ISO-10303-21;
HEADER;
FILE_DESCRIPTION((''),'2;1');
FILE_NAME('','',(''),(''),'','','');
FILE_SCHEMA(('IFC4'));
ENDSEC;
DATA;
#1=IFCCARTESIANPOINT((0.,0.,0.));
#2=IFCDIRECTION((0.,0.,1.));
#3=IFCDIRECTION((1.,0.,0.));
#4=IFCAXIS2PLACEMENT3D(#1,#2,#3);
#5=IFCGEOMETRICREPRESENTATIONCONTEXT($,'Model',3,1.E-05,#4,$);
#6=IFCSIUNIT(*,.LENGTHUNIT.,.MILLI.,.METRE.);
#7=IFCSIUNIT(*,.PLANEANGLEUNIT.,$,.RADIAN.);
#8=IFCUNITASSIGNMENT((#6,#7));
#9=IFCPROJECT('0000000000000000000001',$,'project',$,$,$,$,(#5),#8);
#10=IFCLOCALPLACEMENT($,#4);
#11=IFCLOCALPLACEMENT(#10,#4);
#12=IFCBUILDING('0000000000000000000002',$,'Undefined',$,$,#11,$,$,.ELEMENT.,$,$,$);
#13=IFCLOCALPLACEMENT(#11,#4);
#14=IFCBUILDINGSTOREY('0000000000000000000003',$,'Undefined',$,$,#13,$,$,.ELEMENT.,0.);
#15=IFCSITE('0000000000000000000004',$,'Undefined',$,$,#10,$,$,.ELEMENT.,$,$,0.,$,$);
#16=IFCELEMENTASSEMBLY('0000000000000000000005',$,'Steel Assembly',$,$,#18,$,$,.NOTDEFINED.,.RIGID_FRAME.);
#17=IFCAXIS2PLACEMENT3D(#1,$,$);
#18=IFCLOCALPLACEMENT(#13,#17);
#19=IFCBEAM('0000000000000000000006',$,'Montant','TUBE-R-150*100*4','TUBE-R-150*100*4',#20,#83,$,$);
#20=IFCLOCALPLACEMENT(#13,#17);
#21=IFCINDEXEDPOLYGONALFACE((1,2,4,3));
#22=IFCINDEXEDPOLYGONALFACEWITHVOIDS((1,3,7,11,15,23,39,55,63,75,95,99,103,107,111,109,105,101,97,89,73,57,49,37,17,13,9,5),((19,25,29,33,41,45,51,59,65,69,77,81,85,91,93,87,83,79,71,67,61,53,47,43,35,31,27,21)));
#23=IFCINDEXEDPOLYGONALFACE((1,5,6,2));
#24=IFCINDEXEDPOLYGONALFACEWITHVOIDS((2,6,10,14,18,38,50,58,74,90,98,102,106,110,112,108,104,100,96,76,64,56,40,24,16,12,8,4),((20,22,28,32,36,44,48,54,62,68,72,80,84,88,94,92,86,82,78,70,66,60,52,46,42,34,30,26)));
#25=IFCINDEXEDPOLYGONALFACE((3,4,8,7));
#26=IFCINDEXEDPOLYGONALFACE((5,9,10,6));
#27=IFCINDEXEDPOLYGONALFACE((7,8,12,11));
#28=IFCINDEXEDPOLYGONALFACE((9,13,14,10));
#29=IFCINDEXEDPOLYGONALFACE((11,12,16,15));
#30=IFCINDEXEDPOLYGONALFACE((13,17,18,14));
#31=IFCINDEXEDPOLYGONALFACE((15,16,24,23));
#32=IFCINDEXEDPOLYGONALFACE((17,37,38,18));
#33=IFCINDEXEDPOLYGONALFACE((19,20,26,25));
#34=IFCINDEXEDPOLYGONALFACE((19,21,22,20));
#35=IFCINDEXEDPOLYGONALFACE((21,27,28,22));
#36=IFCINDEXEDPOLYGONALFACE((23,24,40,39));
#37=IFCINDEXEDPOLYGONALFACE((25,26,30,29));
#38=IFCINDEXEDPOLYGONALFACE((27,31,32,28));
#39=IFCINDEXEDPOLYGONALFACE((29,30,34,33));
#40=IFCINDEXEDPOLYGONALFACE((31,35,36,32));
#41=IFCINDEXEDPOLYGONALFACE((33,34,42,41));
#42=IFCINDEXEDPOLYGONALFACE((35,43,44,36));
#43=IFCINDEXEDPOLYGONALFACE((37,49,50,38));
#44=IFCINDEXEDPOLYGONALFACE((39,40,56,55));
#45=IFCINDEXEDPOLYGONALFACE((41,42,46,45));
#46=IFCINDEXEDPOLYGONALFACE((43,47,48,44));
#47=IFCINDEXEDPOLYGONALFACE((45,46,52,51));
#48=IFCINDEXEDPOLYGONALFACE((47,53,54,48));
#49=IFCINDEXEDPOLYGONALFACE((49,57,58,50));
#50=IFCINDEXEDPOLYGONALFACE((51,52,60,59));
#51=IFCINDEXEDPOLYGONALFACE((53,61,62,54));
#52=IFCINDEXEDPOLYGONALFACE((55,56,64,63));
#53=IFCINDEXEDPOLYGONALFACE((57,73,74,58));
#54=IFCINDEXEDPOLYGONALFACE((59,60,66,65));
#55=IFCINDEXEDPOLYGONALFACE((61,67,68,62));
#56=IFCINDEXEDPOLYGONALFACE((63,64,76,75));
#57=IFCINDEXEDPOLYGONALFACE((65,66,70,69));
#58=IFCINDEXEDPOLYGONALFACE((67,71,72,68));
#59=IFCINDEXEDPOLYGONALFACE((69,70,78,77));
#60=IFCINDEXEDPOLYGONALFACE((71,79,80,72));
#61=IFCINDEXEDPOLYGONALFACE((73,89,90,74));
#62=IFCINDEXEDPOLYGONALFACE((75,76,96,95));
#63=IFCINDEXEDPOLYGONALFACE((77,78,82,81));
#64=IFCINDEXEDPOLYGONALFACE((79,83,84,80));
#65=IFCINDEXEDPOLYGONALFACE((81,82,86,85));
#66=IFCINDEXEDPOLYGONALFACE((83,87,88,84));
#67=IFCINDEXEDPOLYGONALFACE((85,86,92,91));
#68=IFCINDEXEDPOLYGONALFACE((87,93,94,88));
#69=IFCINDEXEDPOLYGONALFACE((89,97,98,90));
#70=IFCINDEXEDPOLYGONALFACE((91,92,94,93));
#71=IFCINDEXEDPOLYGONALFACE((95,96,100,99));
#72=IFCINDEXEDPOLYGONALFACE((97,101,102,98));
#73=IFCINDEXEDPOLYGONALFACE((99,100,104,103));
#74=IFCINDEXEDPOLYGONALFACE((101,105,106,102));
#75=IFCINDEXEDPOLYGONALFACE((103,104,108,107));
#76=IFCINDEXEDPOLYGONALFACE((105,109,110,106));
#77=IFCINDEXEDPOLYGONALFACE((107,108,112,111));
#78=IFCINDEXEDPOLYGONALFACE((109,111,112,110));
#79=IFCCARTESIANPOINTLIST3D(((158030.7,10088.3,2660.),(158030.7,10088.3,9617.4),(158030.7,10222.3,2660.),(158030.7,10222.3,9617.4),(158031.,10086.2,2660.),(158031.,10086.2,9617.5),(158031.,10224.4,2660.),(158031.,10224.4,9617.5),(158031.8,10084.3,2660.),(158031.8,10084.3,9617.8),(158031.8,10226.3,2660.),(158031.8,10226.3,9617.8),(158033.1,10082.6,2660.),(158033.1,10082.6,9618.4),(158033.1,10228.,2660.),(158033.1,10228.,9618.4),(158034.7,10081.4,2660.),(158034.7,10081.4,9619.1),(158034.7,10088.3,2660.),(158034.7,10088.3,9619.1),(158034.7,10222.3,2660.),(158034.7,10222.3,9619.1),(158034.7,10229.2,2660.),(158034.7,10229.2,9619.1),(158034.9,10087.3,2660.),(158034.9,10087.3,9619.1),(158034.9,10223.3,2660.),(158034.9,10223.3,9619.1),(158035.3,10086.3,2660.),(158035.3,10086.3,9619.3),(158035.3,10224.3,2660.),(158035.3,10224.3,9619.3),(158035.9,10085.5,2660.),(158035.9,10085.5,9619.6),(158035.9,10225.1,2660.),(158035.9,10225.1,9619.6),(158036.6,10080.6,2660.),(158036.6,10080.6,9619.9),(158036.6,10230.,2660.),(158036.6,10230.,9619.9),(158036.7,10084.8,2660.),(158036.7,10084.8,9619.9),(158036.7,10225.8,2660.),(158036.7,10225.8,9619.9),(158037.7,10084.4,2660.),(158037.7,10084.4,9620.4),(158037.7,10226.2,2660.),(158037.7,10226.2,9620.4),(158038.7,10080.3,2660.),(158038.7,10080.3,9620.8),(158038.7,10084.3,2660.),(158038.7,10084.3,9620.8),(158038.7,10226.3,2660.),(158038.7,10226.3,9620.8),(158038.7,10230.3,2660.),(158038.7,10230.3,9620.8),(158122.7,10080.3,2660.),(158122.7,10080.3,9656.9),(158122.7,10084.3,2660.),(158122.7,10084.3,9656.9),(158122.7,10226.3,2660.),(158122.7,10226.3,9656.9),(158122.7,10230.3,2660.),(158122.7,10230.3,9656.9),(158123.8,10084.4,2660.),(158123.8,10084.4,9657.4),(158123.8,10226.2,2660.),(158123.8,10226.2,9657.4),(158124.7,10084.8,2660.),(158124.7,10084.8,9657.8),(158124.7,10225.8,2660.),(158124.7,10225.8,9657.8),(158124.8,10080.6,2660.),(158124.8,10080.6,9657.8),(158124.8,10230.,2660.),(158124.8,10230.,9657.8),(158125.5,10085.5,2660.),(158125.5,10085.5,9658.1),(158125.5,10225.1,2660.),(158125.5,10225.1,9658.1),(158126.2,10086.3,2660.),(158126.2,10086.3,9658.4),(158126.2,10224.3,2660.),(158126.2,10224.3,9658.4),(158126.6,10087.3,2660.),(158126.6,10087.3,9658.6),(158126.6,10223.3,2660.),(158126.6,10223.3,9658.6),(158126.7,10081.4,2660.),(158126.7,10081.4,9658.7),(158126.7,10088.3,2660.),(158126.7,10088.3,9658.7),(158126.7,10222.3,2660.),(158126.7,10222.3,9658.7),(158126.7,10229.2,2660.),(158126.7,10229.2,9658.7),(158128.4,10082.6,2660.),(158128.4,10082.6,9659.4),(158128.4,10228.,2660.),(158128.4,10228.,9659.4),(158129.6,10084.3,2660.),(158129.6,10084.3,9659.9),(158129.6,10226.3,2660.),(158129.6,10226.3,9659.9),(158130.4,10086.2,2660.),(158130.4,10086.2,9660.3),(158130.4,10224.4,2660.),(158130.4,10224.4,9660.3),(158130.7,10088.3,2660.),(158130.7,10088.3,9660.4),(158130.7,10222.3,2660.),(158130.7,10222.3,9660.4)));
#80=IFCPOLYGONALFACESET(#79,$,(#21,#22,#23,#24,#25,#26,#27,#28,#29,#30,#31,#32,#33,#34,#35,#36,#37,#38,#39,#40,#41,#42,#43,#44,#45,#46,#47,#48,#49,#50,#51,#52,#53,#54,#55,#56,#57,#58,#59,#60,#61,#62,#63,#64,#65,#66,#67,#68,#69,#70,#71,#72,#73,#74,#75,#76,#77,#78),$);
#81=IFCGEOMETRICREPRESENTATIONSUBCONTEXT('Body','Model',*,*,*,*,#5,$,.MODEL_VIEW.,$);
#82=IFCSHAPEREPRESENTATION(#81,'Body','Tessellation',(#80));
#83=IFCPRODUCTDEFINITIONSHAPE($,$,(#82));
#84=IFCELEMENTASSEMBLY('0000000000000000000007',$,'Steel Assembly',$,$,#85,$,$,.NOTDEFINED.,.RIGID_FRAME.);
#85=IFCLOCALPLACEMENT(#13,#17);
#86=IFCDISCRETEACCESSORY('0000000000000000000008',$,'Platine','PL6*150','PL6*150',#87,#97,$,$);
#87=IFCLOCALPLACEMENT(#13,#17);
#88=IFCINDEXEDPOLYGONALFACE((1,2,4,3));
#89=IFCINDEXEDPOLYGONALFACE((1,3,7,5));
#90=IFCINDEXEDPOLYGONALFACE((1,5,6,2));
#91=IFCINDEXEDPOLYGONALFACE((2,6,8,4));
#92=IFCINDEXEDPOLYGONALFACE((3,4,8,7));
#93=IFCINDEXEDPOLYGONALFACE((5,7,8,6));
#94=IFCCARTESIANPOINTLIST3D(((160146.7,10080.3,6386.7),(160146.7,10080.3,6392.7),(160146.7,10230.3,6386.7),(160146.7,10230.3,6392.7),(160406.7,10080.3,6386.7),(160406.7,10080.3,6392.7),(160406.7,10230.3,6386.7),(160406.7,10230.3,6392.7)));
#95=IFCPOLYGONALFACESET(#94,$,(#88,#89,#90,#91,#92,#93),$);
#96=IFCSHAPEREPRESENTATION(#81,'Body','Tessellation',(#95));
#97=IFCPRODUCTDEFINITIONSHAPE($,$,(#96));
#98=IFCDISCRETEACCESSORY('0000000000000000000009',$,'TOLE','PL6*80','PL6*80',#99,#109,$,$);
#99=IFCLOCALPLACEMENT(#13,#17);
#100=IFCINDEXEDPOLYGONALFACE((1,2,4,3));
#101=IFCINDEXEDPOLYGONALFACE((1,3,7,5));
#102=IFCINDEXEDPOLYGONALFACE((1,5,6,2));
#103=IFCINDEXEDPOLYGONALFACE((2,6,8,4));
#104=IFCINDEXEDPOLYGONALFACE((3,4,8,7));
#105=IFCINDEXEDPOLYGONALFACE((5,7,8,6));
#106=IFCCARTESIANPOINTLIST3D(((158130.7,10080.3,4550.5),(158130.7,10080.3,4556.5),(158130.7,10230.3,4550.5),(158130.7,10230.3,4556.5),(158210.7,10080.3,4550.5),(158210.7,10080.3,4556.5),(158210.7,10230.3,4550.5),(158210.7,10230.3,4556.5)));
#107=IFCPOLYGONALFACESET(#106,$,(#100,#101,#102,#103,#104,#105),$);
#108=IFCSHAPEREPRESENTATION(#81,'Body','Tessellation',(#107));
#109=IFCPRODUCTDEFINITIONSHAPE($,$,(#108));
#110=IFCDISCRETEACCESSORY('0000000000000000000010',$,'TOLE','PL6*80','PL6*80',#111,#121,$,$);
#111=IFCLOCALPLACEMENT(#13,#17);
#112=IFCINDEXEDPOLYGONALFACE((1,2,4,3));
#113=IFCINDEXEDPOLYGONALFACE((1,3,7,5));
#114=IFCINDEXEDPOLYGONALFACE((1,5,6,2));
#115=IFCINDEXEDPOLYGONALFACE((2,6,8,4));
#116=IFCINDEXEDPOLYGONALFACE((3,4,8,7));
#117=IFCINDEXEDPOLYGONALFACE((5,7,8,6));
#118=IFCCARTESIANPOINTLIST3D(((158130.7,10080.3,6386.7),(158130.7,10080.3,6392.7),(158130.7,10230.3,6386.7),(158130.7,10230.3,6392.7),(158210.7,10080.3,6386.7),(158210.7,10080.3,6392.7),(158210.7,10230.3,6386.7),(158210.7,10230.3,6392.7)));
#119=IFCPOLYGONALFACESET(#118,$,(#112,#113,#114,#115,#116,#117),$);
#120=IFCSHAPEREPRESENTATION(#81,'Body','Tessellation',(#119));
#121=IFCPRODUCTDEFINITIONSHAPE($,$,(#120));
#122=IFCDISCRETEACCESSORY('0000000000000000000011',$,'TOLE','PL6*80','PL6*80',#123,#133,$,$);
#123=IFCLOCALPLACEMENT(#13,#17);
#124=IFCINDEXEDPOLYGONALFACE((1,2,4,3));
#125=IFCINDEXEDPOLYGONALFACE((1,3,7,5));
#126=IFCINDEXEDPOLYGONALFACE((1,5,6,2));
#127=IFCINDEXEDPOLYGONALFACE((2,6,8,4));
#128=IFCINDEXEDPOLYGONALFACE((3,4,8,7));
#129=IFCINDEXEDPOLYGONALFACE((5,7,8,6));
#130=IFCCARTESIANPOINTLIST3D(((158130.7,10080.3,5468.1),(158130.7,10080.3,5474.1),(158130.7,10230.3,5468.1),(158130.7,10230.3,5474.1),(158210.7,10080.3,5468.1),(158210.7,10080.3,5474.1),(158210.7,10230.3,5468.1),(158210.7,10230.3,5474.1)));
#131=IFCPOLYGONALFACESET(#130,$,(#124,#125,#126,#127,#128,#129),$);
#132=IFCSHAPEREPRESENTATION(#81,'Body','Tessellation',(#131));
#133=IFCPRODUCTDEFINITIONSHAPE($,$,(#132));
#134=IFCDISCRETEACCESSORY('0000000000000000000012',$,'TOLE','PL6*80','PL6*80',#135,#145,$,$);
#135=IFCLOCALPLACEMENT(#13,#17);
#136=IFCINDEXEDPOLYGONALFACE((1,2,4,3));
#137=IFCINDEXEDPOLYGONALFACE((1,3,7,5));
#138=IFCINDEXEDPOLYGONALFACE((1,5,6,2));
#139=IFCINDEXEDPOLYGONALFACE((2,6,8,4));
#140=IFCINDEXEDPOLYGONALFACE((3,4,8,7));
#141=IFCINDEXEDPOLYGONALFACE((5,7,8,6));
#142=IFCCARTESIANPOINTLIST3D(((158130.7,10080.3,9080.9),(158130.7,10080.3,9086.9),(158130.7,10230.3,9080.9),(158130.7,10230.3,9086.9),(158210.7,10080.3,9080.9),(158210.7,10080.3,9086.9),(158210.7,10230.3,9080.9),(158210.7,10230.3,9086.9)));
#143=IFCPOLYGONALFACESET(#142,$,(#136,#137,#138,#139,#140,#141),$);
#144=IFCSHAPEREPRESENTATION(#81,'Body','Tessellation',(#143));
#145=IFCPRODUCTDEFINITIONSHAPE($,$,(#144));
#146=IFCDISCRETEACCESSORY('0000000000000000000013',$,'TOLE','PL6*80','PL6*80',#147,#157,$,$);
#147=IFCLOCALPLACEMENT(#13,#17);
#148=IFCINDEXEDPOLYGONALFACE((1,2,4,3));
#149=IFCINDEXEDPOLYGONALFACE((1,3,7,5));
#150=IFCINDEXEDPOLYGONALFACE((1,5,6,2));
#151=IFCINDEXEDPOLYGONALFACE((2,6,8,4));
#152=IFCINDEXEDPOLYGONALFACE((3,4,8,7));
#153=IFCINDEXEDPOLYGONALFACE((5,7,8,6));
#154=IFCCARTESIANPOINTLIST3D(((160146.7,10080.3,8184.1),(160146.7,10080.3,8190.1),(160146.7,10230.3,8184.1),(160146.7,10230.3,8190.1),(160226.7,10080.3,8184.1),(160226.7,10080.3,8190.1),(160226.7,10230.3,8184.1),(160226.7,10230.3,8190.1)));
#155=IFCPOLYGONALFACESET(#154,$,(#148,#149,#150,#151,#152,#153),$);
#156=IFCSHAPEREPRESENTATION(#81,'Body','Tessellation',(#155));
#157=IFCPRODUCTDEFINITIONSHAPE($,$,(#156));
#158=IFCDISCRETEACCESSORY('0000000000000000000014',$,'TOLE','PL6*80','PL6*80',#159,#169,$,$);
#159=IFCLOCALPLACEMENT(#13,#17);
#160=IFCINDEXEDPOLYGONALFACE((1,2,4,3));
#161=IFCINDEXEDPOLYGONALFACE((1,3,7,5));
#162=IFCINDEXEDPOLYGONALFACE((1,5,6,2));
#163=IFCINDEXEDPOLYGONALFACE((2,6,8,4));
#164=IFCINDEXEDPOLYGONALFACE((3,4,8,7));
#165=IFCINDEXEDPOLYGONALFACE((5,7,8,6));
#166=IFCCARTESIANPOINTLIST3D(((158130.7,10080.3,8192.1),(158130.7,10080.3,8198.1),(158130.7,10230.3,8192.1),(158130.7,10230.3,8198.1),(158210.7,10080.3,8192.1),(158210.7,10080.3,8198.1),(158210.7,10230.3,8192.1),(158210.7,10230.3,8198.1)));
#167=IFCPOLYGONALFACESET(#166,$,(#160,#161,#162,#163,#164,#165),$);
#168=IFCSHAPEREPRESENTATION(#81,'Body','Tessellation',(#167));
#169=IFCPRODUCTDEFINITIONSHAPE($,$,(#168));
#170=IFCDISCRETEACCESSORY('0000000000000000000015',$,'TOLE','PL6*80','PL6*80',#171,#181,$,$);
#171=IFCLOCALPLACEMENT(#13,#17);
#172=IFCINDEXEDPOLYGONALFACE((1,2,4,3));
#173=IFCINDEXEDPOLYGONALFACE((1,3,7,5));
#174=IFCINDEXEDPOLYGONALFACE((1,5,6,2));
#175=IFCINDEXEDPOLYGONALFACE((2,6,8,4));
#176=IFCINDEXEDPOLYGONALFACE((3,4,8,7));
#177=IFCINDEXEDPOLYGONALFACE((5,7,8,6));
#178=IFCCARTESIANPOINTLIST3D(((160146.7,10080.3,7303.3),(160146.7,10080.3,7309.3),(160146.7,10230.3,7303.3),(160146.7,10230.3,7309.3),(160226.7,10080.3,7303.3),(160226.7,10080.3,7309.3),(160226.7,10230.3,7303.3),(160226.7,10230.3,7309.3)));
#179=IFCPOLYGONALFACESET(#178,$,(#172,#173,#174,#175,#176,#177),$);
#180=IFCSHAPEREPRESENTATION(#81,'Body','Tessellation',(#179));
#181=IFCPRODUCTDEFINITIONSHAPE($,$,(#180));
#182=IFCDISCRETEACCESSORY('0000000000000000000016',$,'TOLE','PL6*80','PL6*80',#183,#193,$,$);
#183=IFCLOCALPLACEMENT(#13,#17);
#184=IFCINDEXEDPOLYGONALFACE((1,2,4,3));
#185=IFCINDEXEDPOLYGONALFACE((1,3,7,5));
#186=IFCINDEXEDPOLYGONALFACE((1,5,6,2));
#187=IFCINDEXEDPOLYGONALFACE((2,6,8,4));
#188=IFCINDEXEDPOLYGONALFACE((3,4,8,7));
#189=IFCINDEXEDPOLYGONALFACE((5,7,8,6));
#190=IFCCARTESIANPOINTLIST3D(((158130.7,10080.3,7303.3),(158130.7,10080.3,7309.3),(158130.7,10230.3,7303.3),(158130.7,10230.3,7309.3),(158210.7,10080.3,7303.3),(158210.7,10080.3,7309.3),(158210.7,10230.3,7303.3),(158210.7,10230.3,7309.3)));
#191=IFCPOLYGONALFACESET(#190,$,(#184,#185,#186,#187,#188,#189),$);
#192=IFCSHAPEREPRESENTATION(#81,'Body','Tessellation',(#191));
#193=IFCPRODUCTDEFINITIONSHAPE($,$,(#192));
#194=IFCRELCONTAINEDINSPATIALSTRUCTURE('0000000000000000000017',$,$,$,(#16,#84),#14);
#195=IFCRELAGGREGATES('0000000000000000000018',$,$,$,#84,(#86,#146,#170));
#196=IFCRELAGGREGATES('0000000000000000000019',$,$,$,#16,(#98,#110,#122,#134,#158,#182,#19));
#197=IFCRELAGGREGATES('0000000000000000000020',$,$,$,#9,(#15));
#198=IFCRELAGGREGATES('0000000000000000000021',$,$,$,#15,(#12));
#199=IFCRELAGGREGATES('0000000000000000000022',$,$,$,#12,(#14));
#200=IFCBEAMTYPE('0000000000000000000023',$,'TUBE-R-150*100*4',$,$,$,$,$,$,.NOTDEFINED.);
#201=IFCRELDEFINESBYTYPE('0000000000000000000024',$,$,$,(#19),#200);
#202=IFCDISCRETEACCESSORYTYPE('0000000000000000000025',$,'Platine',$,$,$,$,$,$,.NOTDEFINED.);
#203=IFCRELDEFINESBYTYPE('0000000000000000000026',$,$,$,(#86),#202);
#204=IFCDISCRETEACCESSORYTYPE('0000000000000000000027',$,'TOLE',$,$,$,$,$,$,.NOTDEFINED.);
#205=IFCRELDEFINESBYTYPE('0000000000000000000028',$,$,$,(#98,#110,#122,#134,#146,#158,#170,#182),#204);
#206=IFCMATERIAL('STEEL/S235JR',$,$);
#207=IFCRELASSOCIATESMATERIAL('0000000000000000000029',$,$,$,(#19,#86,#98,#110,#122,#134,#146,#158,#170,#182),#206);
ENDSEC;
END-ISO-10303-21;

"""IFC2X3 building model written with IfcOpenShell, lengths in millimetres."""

from ifc_helpers import new_model, si_unit, frame, origin_with_axes, origin_2d_with_axis, place, context, subcontext, project, spatial, polyline, hollow_rectangle, outline, extrude, clip, halfspace, material, type_object, element, aggregate, save


model = new_model("IFC2X3")

# Units and contexts
model_context = context("Model", 3, precision=1e-05, world=origin_with_axes())
body_context = subcontext(model_context, "Body", "Model", "MODEL_VIEW")
ifc_project = project(units=[si_unit("LENGTHUNIT", "METRE", prefix="MILLI"), si_unit("PLANEANGLEUNIT", "RADIAN")], contexts=[model_context])

# Site, building, storey
site_placement = place(None, origin_with_axes())
site = spatial("IfcSite", under=ifc_project, at=site_placement, Name="Undefined", CompositionType="ELEMENT", RefElevation=0.0)
building_placement = place(site_placement, origin_with_axes())
building = spatial("IfcBuilding", under=site, at=building_placement, Name="Undefined", CompositionType="ELEMENT")
storey_placement = place(building_placement, origin_with_axes())
storey = spatial("IfcBuildingStorey", under=building, at=storey_placement, Name="Undefined", CompositionType="ELEMENT", Elevation=0.0)

# Element assembly, beam
assembly_1_placement = place(storey_placement, origin_with_axes())
assembly_1 = element("IfcElementAssembly", 1, at=assembly_1_placement, inside=storey, Name="Steel Assembly", AssemblyPlace="NOTDEFINED", PredefinedType="RIGID_FRAME")
ifc_material_1 = material(Name="STEEL/S235JR")
beam_type_1 = type_object("IfcBeamType", Name="TUBE-R-150*100*4", PredefinedType="NOTDEFINED")
beam_1_placement = place(assembly_1_placement, frame((158080.7, 10155.3, 9123.1), z_axis=(0.0, 1.0, 0.0), x_axis=(0.0, 0.0, -1.0)))
beam_1 = element("IfcBeam", 2, at=beam_1_placement, type_object=beam_type_1, material=ifc_material_1, Name="Montant", Description="TUBE-R-150*100*4", ObjectType="TUBE-R-150*100*4", context=body_context, shape_type="Clipping", body=[
    clip(extrude(hollow_rectangle(XDim=100.0, YDim=150.0, WallThickness=4.0, InnerFilletRadius=4.0, OuterFilletRadius=8.0, at=origin_2d_with_axis()), frame((6463.0, 0.0, 0.0), z_axis=(-1.0, 0.0, 0.0), x_axis=(0.0, -1.0, 0.0)), (0.0, 0.0, 1.0), 7000.5), halfspace(frame((-494.3, 50.0, 0.0), z_axis=(0.918657, -0.395056, 0.0), x_axis=(0.0, 0.0, -1.0)), True)),
])

# Element assembly, discrete accessory
assembly_2_placement = place(storey_placement, origin_with_axes())
assembly_2 = element("IfcElementAssembly", 3, at=assembly_2_placement, inside=storey, Name="Steel Assembly", AssemblyPlace="NOTDEFINED", PredefinedType="RIGID_FRAME")
discrete_accessory_type_1 = type_object("IfcDiscreteAccessoryType", Name="Platine")
discrete_accessory_1_placement = place(assembly_2_placement, frame((160146.7, 10080.3, 6389.7), z_axis=(0.0, 0.0, 1.0), x_axis=(1.0, 0.0, 0.0)))
discrete_accessory_1 = element("IfcDiscreteAccessory", 4, at=discrete_accessory_1_placement, type_object=discrete_accessory_type_1, material=ifc_material_1, Name="Platine", Description="PL6*150", ObjectType="PL6*150", context=body_context, shape_type="SweptSolid", body=[
    extrude(outline(polyline([(0.0, 0.0), (260.0, 0.0), (260.0, 150.0), (0.0, 150.0), (0.0, 0.0)])), frame((0.0, 0.0, -3.0), z_axis=(0.0, 0.0, 1.0), x_axis=(1.0, 0.0, 0.0)), (0.0, 0.0, 1.0), 6.0),
])

# Discrete accessories
discrete_accessory_type_2 = type_object("IfcDiscreteAccessoryType", Name="TOLE")
discrete_accessory_2_placement = place(assembly_1_placement, frame((158170.7, 10080.3, 4553.5), z_axis=(0.0, 0.0, 1.0), x_axis=(0.0, 1.0, 0.0)))
discrete_accessory_2 = element("IfcDiscreteAccessory", 5, at=discrete_accessory_2_placement, type_object=discrete_accessory_type_2, material=ifc_material_1, Name="TOLE", Description="PL6*80", ObjectType="PL6*80", context=body_context, shape_type="SweptSolid", body=[
    extrude(outline(polyline([(150.0, 40.0), (150.0, -40.0), (0.0, -40.0), (0.0, 40.0), (150.0, 40.0)])), frame((0.0, 0.0, -3.0), z_axis=(0.0, 0.0, 1.0), x_axis=(1.0, 0.0, 0.0)), (0.0, 0.0, 1.0), 6.0),
])
discrete_accessory_3_placement = place(assembly_1_placement, frame((158170.7, 10080.3, 6389.7), z_axis=(0.0, 0.0, 1.0), x_axis=(0.0, 1.0, 0.0)))
discrete_accessory_3 = element("IfcDiscreteAccessory", 6, at=discrete_accessory_3_placement, type_object=discrete_accessory_type_2, material=ifc_material_1, Name="TOLE", Description="PL6*80", ObjectType="PL6*80", context=body_context, shape_type="SweptSolid", body=[
    extrude(outline(polyline([(150.0, 40.0), (150.0, -40.0), (0.0, -40.0), (0.0, 40.0), (150.0, 40.0)])), frame((0.0, 0.0, -3.0), z_axis=(0.0, 0.0, 1.0), x_axis=(1.0, 0.0, 0.0)), (0.0, 0.0, 1.0), 6.0),
])
discrete_accessory_4_placement = place(assembly_1_placement, frame((158170.7, 10080.3, 5471.1), z_axis=(0.0, 0.0, 1.0), x_axis=(0.0, 1.0, 0.0)))
discrete_accessory_4 = element("IfcDiscreteAccessory", 7, at=discrete_accessory_4_placement, type_object=discrete_accessory_type_2, material=ifc_material_1, Name="TOLE", Description="PL6*80", ObjectType="PL6*80", context=body_context, shape_type="SweptSolid", body=[
    extrude(outline(polyline([(150.0, 40.0), (150.0, -40.0), (0.0, -40.0), (0.0, 40.0), (150.0, 40.0)])), frame((0.0, 0.0, -3.0), z_axis=(0.0, 0.0, 1.0), x_axis=(1.0, 0.0, 0.0)), (0.0, 0.0, 1.0), 6.0),
])
discrete_accessory_5_placement = place(assembly_1_placement, frame((158170.7, 10080.3, 9083.9), z_axis=(0.0, 0.0, 1.0), x_axis=(0.0, 1.0, 0.0)))
discrete_accessory_5 = element("IfcDiscreteAccessory", 8, at=discrete_accessory_5_placement, type_object=discrete_accessory_type_2, material=ifc_material_1, Name="TOLE", Description="PL6*80", ObjectType="PL6*80", context=body_context, shape_type="SweptSolid", body=[
    extrude(outline(polyline([(150.0, 40.0), (150.0, -40.0), (0.0, -40.0), (0.0, 40.0), (150.0, 40.0)])), frame((0.0, 0.0, -3.0), z_axis=(0.0, 0.0, 1.0), x_axis=(1.0, 0.0, 0.0)), (0.0, 0.0, 1.0), 6.0),
])
discrete_accessory_6_placement = place(assembly_2_placement, frame((160186.7, 10080.3, 8187.1), z_axis=(0.0, 0.0, -1.0), x_axis=(0.0, 1.0, 0.0)))
discrete_accessory_6 = element("IfcDiscreteAccessory", 9, at=discrete_accessory_6_placement, type_object=discrete_accessory_type_2, material=ifc_material_1, Name="TOLE", Description="PL6*80", ObjectType="PL6*80", context=body_context, shape_type="SweptSolid", body=[
    extrude(outline(polyline([(0.0, 40.0), (150.0, 40.0), (150.0, -40.0), (0.0, -40.0), (0.0, 40.0)])), frame((0.0, 0.0, -3.0), z_axis=(0.0, 0.0, 1.0), x_axis=(1.0, 0.0, 0.0)), (0.0, 0.0, 1.0), 6.0),
])
discrete_accessory_7_placement = place(assembly_1_placement, frame((158170.7, 10080.3, 8195.1), z_axis=(0.0, 0.0, 1.0), x_axis=(0.0, 1.0, 0.0)))
discrete_accessory_7 = element("IfcDiscreteAccessory", 10, at=discrete_accessory_7_placement, type_object=discrete_accessory_type_2, material=ifc_material_1, Name="TOLE", Description="PL6*80", ObjectType="PL6*80", context=body_context, shape_type="SweptSolid", body=[
    extrude(outline(polyline([(150.0, 40.0), (150.0, -40.0), (0.0, -40.0), (0.0, 40.0), (150.0, 40.0)])), frame((0.0, 0.0, -3.0), z_axis=(0.0, 0.0, 1.0), x_axis=(1.0, 0.0, 0.0)), (0.0, 0.0, 1.0), 6.0),
])
discrete_accessory_8_placement = place(assembly_2_placement, frame((160186.7, 10080.3, 7306.3), z_axis=(0.0, 0.0, -1.0), x_axis=(0.0, 1.0, 0.0)))
discrete_accessory_8 = element("IfcDiscreteAccessory", 11, at=discrete_accessory_8_placement, type_object=discrete_accessory_type_2, material=ifc_material_1, Name="TOLE", Description="PL6*80", ObjectType="PL6*80", context=body_context, shape_type="SweptSolid", body=[
    extrude(outline(polyline([(0.0, 40.0), (150.0, 40.0), (150.0, -40.0), (0.0, -40.0), (0.0, 40.0)])), frame((0.0, 0.0, -3.0), z_axis=(0.0, 0.0, 1.0), x_axis=(1.0, 0.0, 0.0)), (0.0, 0.0, 1.0), 6.0),
])
discrete_accessory_9_placement = place(assembly_1_placement, frame((158170.7, 10080.3, 7306.3), z_axis=(0.0, 0.0, 1.0), x_axis=(0.0, 1.0, 0.0)))
discrete_accessory_9 = element("IfcDiscreteAccessory", 12, at=discrete_accessory_9_placement, type_object=discrete_accessory_type_2, material=ifc_material_1, Name="TOLE", Description="PL6*80", ObjectType="PL6*80", context=body_context, shape_type="SweptSolid", body=[
    extrude(outline(polyline([(150.0, 40.0), (150.0, -40.0), (0.0, -40.0), (0.0, 40.0), (150.0, 40.0)])), frame((0.0, 0.0, -3.0), z_axis=(0.0, 0.0, 1.0), x_axis=(1.0, 0.0, 0.0)), (0.0, 0.0, 1.0), 6.0),
])
aggregate(assembly_2, [discrete_accessory_1, discrete_accessory_6, discrete_accessory_8])

aggregate(assembly_1, [discrete_accessory_2, discrete_accessory_3, discrete_accessory_4, discrete_accessory_5, discrete_accessory_7, discrete_accessory_9, beam_1])

save(model, "model.ifc")
